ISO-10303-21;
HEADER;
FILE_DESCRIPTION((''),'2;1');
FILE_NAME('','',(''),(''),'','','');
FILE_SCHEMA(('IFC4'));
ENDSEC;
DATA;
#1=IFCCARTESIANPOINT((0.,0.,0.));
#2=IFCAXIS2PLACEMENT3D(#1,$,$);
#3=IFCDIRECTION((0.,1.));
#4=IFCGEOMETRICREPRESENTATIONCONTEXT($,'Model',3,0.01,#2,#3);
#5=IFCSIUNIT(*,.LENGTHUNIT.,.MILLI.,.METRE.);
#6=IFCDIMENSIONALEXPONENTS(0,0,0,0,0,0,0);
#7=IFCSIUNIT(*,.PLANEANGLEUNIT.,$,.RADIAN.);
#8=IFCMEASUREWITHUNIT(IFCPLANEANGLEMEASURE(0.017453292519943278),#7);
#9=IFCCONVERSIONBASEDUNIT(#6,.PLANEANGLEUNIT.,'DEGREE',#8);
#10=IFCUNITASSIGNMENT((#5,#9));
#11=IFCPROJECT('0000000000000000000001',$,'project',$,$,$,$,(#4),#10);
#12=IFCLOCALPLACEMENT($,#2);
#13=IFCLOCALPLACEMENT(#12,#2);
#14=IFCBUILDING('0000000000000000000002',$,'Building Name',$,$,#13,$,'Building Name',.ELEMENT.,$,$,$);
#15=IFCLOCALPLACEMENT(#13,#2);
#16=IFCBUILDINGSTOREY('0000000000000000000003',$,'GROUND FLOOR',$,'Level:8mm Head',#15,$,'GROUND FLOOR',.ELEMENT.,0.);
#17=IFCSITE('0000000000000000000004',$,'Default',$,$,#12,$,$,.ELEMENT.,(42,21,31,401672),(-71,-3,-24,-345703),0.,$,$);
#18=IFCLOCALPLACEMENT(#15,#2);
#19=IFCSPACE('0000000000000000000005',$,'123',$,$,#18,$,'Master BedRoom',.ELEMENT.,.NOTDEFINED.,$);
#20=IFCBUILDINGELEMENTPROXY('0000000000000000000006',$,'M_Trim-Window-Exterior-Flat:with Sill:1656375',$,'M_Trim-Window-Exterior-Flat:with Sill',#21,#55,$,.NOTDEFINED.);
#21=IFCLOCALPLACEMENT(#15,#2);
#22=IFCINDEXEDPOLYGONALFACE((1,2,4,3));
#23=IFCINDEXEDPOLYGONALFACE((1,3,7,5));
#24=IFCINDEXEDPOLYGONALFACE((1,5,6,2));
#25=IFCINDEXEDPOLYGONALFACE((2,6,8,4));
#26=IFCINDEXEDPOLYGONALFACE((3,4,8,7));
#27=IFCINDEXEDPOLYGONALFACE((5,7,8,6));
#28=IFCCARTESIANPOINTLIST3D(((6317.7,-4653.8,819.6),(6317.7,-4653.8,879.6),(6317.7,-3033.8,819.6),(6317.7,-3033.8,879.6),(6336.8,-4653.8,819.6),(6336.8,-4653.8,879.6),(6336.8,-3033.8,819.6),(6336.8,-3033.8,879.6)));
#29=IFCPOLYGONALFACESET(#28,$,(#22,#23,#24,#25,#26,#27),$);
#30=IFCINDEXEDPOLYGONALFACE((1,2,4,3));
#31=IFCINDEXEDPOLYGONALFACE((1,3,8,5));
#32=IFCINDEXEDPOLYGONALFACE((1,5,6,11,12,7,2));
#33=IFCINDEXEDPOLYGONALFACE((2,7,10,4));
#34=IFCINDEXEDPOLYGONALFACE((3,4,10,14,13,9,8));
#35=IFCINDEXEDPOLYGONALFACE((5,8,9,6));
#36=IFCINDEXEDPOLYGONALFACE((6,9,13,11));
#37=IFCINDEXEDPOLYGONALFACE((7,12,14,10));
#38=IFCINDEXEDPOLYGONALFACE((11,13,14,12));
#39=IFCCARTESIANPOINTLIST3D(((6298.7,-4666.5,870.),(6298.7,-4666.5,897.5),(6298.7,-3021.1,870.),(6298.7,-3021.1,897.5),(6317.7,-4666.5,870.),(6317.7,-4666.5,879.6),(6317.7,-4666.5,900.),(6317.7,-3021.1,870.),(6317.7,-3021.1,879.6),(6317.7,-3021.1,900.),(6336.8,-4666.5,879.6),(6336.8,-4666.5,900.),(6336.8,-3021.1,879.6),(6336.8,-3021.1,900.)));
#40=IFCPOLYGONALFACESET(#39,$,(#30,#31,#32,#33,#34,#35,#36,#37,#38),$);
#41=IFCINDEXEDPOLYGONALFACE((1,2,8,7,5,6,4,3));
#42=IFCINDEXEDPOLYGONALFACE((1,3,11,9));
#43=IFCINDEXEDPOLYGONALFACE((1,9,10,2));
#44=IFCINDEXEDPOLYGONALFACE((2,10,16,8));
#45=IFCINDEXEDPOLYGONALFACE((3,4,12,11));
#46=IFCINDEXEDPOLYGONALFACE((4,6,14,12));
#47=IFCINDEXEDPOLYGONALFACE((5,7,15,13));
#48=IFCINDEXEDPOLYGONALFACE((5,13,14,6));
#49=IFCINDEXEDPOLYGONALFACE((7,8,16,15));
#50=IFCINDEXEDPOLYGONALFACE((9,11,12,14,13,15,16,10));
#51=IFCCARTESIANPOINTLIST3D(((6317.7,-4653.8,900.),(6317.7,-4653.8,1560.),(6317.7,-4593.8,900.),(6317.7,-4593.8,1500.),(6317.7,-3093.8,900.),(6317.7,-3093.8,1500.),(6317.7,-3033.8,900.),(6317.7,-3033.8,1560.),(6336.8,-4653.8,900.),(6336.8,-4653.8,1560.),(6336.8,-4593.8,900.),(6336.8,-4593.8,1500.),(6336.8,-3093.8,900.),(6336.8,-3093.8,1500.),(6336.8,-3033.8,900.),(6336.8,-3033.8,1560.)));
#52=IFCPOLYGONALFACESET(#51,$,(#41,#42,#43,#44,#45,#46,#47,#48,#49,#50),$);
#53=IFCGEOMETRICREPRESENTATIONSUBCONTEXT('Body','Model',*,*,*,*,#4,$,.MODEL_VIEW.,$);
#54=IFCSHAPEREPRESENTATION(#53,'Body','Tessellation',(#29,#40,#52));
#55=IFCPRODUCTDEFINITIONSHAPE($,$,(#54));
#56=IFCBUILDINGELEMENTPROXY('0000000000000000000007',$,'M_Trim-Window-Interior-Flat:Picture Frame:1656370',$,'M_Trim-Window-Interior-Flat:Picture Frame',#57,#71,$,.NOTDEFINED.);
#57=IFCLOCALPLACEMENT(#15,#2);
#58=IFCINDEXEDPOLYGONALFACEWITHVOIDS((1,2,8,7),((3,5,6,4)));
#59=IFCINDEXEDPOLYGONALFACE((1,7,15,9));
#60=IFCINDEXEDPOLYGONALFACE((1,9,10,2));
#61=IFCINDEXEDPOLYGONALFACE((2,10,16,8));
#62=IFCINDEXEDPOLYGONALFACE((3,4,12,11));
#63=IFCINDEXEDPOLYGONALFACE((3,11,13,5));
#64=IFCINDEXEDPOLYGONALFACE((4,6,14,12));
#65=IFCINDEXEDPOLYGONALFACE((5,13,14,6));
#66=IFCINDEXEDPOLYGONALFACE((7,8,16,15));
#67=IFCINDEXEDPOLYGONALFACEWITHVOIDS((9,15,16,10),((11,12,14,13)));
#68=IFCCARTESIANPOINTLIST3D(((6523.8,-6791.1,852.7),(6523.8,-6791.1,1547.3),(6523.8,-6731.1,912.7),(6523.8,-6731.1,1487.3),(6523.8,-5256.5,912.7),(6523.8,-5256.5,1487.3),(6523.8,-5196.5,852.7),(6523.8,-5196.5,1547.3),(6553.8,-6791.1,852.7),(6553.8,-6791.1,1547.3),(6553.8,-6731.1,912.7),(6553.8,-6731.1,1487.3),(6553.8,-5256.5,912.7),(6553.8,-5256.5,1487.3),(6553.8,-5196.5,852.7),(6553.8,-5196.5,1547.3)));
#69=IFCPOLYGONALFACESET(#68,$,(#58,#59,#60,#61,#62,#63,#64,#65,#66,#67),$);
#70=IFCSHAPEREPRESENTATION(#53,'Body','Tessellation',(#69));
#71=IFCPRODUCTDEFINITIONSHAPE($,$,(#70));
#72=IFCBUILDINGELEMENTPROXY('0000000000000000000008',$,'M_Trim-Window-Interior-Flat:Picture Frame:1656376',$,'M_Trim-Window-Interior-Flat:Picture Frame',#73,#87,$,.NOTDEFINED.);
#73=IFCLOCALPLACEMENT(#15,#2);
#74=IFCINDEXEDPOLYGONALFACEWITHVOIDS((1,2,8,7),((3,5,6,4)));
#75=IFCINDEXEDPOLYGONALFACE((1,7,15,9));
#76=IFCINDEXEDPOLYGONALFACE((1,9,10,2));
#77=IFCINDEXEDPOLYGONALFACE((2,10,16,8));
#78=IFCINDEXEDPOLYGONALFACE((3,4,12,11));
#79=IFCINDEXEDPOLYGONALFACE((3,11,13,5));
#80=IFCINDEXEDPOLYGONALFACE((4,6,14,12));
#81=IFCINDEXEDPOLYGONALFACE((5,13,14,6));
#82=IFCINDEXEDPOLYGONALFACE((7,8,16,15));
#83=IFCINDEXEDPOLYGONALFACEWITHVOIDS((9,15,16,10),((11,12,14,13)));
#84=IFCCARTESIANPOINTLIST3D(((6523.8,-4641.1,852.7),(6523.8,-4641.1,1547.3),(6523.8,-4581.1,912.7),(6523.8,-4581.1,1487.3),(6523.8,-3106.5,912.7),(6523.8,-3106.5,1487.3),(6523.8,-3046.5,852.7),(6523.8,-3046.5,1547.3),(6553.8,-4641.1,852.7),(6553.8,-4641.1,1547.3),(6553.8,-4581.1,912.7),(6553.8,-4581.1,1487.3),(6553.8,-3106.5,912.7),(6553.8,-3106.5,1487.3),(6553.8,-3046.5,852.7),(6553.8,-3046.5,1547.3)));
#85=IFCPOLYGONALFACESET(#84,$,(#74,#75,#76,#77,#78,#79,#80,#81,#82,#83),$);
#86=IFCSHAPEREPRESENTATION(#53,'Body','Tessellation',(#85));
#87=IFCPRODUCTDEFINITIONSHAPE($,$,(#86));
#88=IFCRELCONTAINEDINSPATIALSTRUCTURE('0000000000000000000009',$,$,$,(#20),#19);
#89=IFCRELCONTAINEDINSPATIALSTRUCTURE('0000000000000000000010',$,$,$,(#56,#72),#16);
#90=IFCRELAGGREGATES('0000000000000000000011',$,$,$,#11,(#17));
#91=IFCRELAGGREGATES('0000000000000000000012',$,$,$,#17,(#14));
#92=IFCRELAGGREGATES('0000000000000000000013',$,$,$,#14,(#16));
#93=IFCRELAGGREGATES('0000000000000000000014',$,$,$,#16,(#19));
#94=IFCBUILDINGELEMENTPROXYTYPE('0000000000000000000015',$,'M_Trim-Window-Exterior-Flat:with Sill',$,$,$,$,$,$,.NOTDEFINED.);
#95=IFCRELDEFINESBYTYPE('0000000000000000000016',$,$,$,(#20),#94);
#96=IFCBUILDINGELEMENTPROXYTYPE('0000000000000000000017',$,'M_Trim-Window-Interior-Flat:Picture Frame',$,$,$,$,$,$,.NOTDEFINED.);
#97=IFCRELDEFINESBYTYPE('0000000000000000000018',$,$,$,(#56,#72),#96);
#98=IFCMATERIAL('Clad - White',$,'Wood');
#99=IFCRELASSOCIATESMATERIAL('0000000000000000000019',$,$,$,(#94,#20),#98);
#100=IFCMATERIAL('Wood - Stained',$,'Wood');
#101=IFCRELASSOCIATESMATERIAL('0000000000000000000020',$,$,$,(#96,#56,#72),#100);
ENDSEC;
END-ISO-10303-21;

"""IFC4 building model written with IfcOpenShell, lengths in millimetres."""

from ifc_helpers import new_model, entity, si_unit, converted_unit, direction, frame, origin, place, context, subcontext, project, spatial, indexed_curve, outline, extrude, source, transform, mapped, material, type_object, type_shapes, element, save


model = new_model("IFC4")

# Units and contexts
model_context = context("Model", 3, precision=0.01, world=origin(), true_north=direction((0.0, 1.0)))
body_context = subcontext(model_context, "Body", "Model", "MODEL_VIEW")
ifc_project = project(units=[si_unit("LENGTHUNIT", "METRE", prefix="MILLI"), converted_unit("PLANEANGLEUNIT", "DEGREE", entity("IfcPlaneAngleMeasure", 0.017453292519943278), si_unit("PLANEANGLEUNIT", "RADIAN"), dimensions=[0, 0, 0, 0, 0, 0, 0])], contexts=[model_context])

# Site, building, storey
site_placement = place(None, origin())
site = spatial("IfcSite", under=ifc_project, at=site_placement, Name="Default", CompositionType="ELEMENT", RefLatitude=(42, 21, 31, 401672), RefLongitude=(-71, -3, -24, -345703), RefElevation=0.0)
building_placement = place(site_placement, origin())
building = spatial("IfcBuilding", under=site, at=building_placement, Name="Building Name", LongName="Building Name", CompositionType="ELEMENT")
storey_placement = place(building_placement, origin())
storey = spatial("IfcBuildingStorey", under=building, at=storey_placement, Name="GROUND FLOOR", ObjectType="Level:8mm Head", LongName="GROUND FLOOR", CompositionType="ELEMENT", Elevation=0.0)

# Shared definitions
ifc_material_1 = material(Name="Wood - Stained", Category="Wood")

# Shared definitions
space_1_placement = place(storey_placement, origin())
space_1 = spatial("IfcSpace", under=storey, at=space_1_placement, Name="123", LongName="Master BedRoom", CompositionType="ELEMENT", PredefinedType="NOTDEFINED")

# Building element proxies
ifc_material_2 = material(Name="Clad - White", Category="Wood")
building_element_proxy_type_1 = type_object("IfcBuildingElementProxyType", Name="M_Trim-Window-Exterior-Flat:with Sill", PredefinedType="NOTDEFINED", material=ifc_material_2)
shared_shape_1 = source(origin(), body_context, "Body", "SweptSolid", [
    extrude(outline(indexed_curve([(-30.0, -810.0), (30.0, -810.0), (30.0, 810.0), (-30.0, 810.0), (-30.0, -810.0)], self_intersect=False)), frame((0.0, 650.4, 0.0), z_axis=(0.0, 0.0, 1.0), x_axis=(0.0, 1.0, 0.0)), (0.0, 0.0, 1.0), 19.0),
    extrude(outline(indexed_curve([(-15.2, -19.0), (12.3, -19.0), (14.8, 0.0), (14.8, 19.0), (-5.7, 19.0), (-5.7, 0.0), (-15.2, 0.0), (-15.2, -19.0)], self_intersect=False)), frame((-822.7, 614.8, 19.0), z_axis=(1.0, 0.0, 0.0), x_axis=(0.0, -1.0, 0.0)), (0.0, 0.0, 1.0), 1645.4),
    extrude(outline(indexed_curve([(-810.0, -345.0), (810.0, -345.0), (810.0, 315.0), (750.0, 315.0), (750.0, -285.0), (-750.0, -285.0), (-750.0, 315.0), (-810.0, 315.0), (-810.0, -345.0)], self_intersect=False)), frame((0.0, 285.0, 0.0)), (0.0, 0.0, 1.0), 19.0),
])
type_shapes(building_element_proxy_type_1, [shared_shape_1])
for number, where, z_axis, x_axis, name in (
    (1, (6336.8, -3843.8, 1500.0), (-1.0, 0.0, 0.0), (0.0, 1.0, 0.0), "M_Trim-Window-Exterior-Flat:with Sill:1656375"),
):
    element("IfcBuildingElementProxy", number, at=place(space_1_placement, frame(where, z_axis=z_axis, x_axis=x_axis)), inside=space_1, type_object=building_element_proxy_type_1, material=ifc_material_2, Name=name, ObjectType="M_Trim-Window-Exterior-Flat:with Sill", PredefinedType="NOTDEFINED", context=body_context, shape_type="MappedRepresentation", body=[
        mapped(shared_shape_1, transform((0.0, 0.0, 0.0), scale=1.0)),
    ])
building_element_proxy_type_2 = type_object("IfcBuildingElementProxyType", Name="M_Trim-Window-Interior-Flat:Picture Frame", PredefinedType="NOTDEFINED", material=ifc_material_1)
shared_shape_2 = source(origin(), body_context, "Body", "SweptSolid", [
    extrude(outline(indexed_curve([(-347.3, -797.3), (347.3, -797.3), (347.3, 797.3), (-347.3, 797.3), (-347.3, -797.3)], self_intersect=False), holes=[indexed_curve([(-287.3, -737.3), (-287.3, 737.3), (287.3, 737.3), (287.3, -737.3), (-287.3, -737.3)], self_intersect=False)]), frame((0.0, 300.0, 0.0), z_axis=(0.0, 0.0, 1.0), x_axis=(0.0, 1.0, 0.0)), (0.0, 0.0, 1.0), 30.0),
])
type_shapes(building_element_proxy_type_2, [shared_shape_2])
for number, where, z_axis, x_axis, name in (
    (2, (6523.8, -5993.8, 1500.0), (1.0, 0.0, 0.0), (0.0, -1.0, 0.0), "M_Trim-Window-Interior-Flat:Picture Frame:1656370"),
    (3, (6523.8, -3843.8, 1500.0), (1.0, 0.0, 0.0), (0.0, -1.0, 0.0), "M_Trim-Window-Interior-Flat:Picture Frame:1656376"),
):
    element("IfcBuildingElementProxy", number, at=place(storey_placement, frame(where, z_axis=z_axis, x_axis=x_axis)), inside=storey, type_object=building_element_proxy_type_2, material=ifc_material_1, Name=name, ObjectType="M_Trim-Window-Interior-Flat:Picture Frame", PredefinedType="NOTDEFINED", context=body_context, shape_type="MappedRepresentation", body=[
        mapped(shared_shape_2, transform((0.0, 0.0, 0.0), scale=1.0)),
    ])

save(model, "model.ifc")
